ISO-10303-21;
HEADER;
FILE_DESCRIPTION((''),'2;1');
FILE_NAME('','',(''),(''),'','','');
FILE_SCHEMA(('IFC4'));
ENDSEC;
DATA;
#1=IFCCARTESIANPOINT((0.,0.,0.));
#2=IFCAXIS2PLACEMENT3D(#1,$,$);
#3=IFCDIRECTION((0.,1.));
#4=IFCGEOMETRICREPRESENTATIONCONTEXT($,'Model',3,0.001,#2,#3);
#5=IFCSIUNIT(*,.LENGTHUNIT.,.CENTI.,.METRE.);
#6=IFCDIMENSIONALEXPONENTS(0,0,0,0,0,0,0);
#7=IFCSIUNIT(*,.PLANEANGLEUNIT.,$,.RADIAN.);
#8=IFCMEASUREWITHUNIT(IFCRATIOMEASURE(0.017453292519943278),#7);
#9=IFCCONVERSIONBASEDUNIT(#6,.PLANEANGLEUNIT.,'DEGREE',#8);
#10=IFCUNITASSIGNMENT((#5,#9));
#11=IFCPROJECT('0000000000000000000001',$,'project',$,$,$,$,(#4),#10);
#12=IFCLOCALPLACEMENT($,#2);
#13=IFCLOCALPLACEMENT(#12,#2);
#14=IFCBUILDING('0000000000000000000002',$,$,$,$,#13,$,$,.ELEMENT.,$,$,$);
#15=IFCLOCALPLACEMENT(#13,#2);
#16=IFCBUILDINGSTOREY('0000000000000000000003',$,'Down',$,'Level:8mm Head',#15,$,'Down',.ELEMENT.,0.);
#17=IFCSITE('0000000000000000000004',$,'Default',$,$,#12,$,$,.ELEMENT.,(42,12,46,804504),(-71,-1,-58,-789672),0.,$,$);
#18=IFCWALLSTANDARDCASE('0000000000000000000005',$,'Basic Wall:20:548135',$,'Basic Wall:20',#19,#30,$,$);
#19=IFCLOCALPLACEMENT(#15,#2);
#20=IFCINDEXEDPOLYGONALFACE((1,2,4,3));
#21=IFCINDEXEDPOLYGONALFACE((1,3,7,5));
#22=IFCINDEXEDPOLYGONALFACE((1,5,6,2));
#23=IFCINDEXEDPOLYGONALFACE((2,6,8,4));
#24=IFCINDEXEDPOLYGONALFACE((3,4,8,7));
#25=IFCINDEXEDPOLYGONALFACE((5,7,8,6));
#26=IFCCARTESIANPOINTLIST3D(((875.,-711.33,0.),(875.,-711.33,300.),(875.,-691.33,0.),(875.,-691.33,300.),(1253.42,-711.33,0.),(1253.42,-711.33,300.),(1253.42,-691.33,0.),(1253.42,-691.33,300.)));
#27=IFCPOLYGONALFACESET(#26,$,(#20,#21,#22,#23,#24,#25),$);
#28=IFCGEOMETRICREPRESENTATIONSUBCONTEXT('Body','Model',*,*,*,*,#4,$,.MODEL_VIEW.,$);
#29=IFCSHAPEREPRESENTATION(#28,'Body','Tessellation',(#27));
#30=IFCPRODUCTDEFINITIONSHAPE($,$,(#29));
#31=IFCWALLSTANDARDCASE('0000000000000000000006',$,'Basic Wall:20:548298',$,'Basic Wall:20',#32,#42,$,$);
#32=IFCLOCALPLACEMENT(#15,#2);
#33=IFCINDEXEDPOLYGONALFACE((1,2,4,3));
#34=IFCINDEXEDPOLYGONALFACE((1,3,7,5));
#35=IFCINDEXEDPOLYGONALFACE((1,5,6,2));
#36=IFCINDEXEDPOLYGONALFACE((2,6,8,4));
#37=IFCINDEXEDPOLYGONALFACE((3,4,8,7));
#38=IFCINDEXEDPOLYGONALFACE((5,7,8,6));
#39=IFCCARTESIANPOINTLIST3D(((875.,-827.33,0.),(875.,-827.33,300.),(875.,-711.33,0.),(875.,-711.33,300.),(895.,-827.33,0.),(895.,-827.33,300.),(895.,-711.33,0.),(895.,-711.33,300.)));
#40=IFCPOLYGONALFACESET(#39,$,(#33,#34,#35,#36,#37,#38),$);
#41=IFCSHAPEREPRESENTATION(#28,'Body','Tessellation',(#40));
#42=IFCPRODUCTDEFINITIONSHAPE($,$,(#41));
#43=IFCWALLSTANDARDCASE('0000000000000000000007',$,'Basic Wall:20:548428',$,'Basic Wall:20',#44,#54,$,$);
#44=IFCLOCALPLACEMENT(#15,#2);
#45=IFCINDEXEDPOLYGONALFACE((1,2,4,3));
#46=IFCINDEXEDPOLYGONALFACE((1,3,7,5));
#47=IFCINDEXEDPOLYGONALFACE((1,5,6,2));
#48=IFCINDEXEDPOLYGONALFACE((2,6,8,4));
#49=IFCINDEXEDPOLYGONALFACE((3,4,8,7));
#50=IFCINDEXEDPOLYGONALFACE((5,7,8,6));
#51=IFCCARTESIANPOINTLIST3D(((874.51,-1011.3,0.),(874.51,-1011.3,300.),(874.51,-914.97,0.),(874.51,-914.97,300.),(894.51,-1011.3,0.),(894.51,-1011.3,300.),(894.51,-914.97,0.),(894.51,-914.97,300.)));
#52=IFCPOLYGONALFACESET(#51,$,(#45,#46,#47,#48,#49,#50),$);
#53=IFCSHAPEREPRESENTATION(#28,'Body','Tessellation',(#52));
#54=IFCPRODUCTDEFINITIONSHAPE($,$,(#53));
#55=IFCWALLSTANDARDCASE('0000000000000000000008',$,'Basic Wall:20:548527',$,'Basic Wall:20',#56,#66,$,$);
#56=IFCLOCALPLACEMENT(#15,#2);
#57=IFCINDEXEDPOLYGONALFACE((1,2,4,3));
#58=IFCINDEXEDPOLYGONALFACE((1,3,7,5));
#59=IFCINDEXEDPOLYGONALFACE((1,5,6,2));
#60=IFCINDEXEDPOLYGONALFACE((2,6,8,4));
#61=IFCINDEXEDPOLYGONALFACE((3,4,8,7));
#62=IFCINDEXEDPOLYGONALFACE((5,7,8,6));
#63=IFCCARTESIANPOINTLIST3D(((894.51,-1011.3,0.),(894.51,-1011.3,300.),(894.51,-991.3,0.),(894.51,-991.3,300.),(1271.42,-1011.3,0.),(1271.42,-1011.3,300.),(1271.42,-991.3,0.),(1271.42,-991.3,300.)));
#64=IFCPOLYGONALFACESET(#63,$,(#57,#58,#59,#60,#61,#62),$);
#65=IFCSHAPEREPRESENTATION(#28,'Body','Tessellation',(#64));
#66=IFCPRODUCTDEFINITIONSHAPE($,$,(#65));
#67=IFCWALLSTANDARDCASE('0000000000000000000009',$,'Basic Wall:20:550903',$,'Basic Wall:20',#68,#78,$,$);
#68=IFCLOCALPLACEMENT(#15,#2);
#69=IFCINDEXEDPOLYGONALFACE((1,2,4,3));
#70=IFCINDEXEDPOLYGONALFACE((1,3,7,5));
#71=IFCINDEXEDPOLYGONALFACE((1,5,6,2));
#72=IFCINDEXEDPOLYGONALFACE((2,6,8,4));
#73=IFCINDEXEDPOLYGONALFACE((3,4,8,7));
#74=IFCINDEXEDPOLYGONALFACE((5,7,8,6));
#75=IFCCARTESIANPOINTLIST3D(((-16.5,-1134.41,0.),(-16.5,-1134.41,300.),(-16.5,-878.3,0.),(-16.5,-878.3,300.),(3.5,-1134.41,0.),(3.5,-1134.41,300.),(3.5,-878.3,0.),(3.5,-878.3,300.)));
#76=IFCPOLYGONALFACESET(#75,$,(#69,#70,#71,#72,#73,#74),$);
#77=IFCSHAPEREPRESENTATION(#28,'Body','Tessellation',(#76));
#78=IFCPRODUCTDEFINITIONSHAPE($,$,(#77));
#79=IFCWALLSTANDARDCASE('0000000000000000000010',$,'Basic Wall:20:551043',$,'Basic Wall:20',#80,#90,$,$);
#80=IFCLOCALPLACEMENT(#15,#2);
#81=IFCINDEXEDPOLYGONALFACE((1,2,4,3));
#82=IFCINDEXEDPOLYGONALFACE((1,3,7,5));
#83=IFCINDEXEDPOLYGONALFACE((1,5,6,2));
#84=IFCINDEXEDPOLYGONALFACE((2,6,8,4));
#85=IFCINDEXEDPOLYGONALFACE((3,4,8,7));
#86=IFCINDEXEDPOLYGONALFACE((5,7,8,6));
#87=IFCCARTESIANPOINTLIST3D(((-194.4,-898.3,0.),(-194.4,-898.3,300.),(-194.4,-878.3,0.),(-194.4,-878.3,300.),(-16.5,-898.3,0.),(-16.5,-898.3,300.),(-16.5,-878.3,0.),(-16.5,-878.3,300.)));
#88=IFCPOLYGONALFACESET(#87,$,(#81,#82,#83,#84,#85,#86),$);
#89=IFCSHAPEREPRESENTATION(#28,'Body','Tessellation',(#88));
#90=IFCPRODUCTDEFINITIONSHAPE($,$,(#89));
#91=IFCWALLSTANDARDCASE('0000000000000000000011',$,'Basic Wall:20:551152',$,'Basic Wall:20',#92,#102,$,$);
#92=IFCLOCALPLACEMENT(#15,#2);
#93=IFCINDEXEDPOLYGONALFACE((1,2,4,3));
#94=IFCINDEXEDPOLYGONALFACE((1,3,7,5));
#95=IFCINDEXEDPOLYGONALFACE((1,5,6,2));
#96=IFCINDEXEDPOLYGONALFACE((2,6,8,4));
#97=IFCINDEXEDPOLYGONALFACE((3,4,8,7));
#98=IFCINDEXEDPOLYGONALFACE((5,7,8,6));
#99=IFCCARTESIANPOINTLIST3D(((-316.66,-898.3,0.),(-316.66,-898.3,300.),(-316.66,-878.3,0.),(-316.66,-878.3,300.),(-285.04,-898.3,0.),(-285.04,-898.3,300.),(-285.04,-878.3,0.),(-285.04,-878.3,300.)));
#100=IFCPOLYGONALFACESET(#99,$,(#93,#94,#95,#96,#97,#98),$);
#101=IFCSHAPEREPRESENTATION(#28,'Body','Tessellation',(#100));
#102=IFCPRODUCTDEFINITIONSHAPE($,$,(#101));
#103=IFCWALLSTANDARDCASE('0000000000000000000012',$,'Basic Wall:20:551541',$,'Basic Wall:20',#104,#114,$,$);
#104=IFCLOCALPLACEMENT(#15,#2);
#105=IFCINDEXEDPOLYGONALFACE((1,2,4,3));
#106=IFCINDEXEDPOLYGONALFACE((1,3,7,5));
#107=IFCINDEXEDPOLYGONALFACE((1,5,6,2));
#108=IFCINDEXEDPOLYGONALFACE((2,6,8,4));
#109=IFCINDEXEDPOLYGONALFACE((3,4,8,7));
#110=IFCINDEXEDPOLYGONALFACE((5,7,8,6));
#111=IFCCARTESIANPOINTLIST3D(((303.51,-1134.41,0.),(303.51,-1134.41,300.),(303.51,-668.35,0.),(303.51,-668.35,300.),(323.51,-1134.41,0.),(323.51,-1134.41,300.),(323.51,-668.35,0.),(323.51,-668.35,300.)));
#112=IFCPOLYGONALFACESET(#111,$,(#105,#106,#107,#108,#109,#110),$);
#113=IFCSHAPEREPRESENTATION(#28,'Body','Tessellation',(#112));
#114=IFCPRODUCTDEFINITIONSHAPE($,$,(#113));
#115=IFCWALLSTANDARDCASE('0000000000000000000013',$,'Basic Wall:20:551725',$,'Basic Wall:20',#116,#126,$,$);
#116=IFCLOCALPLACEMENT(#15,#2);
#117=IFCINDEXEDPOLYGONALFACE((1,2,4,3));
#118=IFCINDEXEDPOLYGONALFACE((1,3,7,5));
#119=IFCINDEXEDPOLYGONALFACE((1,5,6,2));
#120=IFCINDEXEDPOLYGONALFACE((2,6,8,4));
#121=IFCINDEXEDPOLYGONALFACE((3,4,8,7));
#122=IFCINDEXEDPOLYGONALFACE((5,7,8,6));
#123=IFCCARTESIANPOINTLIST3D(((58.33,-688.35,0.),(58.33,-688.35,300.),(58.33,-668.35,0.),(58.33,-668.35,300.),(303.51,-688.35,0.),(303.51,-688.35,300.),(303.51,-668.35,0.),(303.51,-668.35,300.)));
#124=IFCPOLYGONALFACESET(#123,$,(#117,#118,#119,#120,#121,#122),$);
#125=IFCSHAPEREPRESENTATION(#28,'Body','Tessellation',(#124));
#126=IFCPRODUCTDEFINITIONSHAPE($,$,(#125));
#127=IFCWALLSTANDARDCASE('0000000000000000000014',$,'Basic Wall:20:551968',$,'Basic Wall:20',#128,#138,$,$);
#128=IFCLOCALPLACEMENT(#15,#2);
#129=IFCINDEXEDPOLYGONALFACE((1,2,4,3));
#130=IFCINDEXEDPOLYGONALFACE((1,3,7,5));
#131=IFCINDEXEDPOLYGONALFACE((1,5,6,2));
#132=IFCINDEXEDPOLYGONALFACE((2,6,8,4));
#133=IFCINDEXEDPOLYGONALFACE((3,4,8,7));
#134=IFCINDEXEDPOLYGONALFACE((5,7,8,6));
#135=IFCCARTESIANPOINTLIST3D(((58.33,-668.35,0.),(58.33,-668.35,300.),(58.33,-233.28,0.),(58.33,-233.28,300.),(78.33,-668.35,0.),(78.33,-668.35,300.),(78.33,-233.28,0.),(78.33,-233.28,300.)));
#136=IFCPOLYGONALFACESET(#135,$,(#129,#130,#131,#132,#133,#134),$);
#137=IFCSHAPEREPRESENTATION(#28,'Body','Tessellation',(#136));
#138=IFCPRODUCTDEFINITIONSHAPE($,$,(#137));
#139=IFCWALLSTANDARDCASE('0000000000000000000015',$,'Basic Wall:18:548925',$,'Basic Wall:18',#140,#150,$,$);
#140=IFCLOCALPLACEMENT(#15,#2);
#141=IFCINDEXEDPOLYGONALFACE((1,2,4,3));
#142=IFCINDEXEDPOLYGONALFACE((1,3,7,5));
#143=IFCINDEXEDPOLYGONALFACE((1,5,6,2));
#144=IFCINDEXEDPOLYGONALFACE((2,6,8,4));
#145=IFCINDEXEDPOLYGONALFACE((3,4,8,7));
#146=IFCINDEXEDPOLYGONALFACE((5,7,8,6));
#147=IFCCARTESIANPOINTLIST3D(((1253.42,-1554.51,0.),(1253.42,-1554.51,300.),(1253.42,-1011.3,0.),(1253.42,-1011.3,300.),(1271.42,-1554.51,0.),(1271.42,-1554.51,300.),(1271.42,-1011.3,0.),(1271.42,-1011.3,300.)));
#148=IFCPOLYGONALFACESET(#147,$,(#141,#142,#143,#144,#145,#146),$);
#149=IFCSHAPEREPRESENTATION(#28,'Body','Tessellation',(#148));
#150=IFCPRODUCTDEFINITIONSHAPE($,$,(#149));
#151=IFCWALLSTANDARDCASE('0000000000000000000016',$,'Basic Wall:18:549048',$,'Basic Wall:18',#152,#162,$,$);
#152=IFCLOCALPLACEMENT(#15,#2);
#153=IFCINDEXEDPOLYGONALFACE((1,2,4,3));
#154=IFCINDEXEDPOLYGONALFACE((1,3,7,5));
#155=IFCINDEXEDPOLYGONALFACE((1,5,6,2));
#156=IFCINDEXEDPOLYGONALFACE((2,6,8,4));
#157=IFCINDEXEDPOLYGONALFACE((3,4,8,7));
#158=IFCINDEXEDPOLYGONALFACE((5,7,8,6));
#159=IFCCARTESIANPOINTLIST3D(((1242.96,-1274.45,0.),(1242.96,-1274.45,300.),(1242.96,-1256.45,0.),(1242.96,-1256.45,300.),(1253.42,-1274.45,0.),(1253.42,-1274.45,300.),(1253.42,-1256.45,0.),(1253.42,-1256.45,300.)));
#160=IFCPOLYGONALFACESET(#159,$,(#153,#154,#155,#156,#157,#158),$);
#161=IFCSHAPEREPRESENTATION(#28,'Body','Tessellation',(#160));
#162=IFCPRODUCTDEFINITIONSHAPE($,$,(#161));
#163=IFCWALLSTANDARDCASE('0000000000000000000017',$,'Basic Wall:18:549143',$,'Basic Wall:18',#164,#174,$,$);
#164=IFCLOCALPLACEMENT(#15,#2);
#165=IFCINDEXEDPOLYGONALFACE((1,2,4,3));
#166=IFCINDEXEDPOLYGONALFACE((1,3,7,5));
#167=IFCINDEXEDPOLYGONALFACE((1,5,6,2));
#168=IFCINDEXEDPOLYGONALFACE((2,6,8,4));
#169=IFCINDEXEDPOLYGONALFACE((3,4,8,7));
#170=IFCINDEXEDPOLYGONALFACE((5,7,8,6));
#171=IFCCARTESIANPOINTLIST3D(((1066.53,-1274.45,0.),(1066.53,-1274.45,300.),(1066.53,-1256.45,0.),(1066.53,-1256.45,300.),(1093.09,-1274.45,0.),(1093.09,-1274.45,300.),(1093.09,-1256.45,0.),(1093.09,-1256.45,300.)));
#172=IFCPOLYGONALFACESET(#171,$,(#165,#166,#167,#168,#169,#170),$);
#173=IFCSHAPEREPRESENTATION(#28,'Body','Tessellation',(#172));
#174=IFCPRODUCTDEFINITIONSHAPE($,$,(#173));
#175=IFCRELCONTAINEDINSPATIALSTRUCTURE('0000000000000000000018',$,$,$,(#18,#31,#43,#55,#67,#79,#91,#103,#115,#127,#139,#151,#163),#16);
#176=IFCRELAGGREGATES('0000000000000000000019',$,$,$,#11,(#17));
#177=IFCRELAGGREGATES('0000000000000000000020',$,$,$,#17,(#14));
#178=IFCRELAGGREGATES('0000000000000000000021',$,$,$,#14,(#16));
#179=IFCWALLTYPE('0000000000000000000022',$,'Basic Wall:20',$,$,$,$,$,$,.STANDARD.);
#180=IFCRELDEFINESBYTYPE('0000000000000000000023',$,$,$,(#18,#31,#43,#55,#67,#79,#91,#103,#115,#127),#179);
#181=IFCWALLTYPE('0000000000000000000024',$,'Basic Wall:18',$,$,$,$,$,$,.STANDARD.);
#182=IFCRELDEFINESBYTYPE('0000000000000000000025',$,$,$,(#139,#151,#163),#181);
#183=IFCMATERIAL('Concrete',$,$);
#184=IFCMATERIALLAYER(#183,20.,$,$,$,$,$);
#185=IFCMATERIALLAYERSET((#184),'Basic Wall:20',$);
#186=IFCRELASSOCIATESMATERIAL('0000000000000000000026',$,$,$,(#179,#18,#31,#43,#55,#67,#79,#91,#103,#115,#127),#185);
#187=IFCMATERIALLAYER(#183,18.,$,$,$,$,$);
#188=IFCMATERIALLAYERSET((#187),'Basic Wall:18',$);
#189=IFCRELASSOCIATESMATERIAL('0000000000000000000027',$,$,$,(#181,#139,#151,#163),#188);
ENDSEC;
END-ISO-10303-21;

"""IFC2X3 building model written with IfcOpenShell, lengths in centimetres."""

from ifc_helpers import new_model, entity, si_unit, converted_unit, direction, frame, frame_2d, origin, place, context, subcontext, project, spatial, rectangle, extrude, material, layer, layer_set, layer_usage, type_object, element, save


model = new_model("IFC2X3")

# Units and contexts
model_context = context("Model", 3, precision=0.001, world=origin(), true_north=direction((0.0, 1.0)))
body_context = subcontext(model_context, "Body", "Model", "MODEL_VIEW")
ifc_project = project(units=[si_unit("LENGTHUNIT", "METRE", prefix="CENTI"), converted_unit("PLANEANGLEUNIT", "DEGREE", entity("IfcRatioMeasure", 0.017453292519943278), si_unit("PLANEANGLEUNIT", "RADIAN"), dimensions=[0, 0, 0, 0, 0, 0, 0])], contexts=[model_context])

# Site, building, storey
site_placement = place(None, origin())
site = spatial("IfcSite", under=ifc_project, at=site_placement, Name="Default", CompositionType="ELEMENT", RefLatitude=(42, 12, 46, 804504), RefLongitude=(-71, -1, -58, -789672), RefElevation=0.0)
building_placement = place(site_placement, origin())
building = spatial("IfcBuilding", under=site, at=building_placement, CompositionType="ELEMENT")
storey_placement = place(building_placement, origin())
storey = spatial("IfcBuildingStorey", under=building, at=storey_placement, Name="Down", ObjectType="Level:8mm Head", LongName="Down", CompositionType="ELEMENT", Elevation=0.0)

# Walls
ifc_material = material(Name="Concrete")
ifc_layer_1 = layer(ifc_material, 20.0)
ifc_layer_set_1 = layer_set([ifc_layer_1], Name="Basic Wall:20")
ifc_layer_usage_1 = layer_usage(ifc_layer_set_1, "AXIS2", "POSITIVE", -10.0)
wall_type_1 = type_object("IfcWallType", Name="Basic Wall:20", PredefinedType="STANDARD", material=ifc_layer_set_1)
wall_1_placement = place(storey_placement, frame((1253.42, -701.33, 0.0), z_axis=(0.0, 0.0, 1.0), x_axis=(-1.0, 0.0, 0.0)))
element("IfcWallStandardCase", 1, at=wall_1_placement, inside=storey, type_object=wall_type_1, material=ifc_layer_usage_1, Name="Basic Wall:20:548135", ObjectType="Basic Wall:20", context=body_context, shape_type="SweptSolid", body=[
    extrude(rectangle(XDim=378.42, YDim=20.0, at=frame_2d((189.21, 0.0), x_axis=(-1.0, 0.0))), origin(), (0.0, 0.0, 1.0), 300.0),
])
ifc_layer_usage_2 = layer_usage(ifc_layer_set_1, "AXIS2", "POSITIVE", -10.0)
wall_2_placement = place(storey_placement, frame((885.0, -711.33, 0.0), z_axis=(0.0, 0.0, 1.0), x_axis=(0.0, -1.0, 0.0)))
element("IfcWallStandardCase", 2, at=wall_2_placement, inside=storey, type_object=wall_type_1, material=ifc_layer_usage_2, Name="Basic Wall:20:548298", ObjectType="Basic Wall:20", context=body_context, shape_type="SweptSolid", body=[
    extrude(rectangle(XDim=116.0, YDim=20.0, at=frame_2d((58.0, 0.0), x_axis=(-1.0, 0.0))), origin(), (0.0, 0.0, 1.0), 300.0),
])
ifc_layer_usage_3 = layer_usage(ifc_layer_set_1, "AXIS2", "POSITIVE", -10.0)
wall_3_placement = place(storey_placement, frame((884.51, -914.97, 0.0), z_axis=(0.0, 0.0, 1.0), x_axis=(0.0, -1.0, 0.0)))
element("IfcWallStandardCase", 3, at=wall_3_placement, inside=storey, type_object=wall_type_1, material=ifc_layer_usage_3, Name="Basic Wall:20:548428", ObjectType="Basic Wall:20", context=body_context, shape_type="SweptSolid", body=[
    extrude(rectangle(XDim=96.33, YDim=20.0, at=frame_2d((48.17, 0.0), x_axis=(-1.0, 0.0))), origin(), (0.0, 0.0, 1.0), 300.0),
])
ifc_layer_usage_4 = layer_usage(ifc_layer_set_1, "AXIS2", "POSITIVE", -10.0)
wall_4_placement = place(storey_placement, frame((894.51, -1001.3, 0.0)))
element("IfcWallStandardCase", 4, at=wall_4_placement, inside=storey, type_object=wall_type_1, material=ifc_layer_usage_4, Name="Basic Wall:20:548527", ObjectType="Basic Wall:20", context=body_context, shape_type="SweptSolid", body=[
    extrude(rectangle(XDim=376.91, YDim=20.0, at=frame_2d((188.46, 0.0), x_axis=(-1.0, 0.0))), origin(), (0.0, 0.0, 1.0), 300.0),
])
ifc_layer_usage_5 = layer_usage(ifc_layer_set_1, "AXIS2", "NEGATIVE", 10.0)
wall_5_placement = place(storey_placement, frame((-6.5, -1134.41, 0.0), z_axis=(0.0, 0.0, 1.0), x_axis=(0.0, 1.0, 0.0)))
element("IfcWallStandardCase", 5, at=wall_5_placement, inside=storey, type_object=wall_type_1, material=ifc_layer_usage_5, Name="Basic Wall:20:550903", ObjectType="Basic Wall:20", context=body_context, shape_type="SweptSolid", body=[
    extrude(rectangle(XDim=256.11, YDim=20.0, at=frame_2d((128.05, 0.0), x_axis=(-1.0, 0.0))), origin(), (0.0, 0.0, 1.0), 300.0),
])
ifc_layer_usage_6 = layer_usage(ifc_layer_set_1, "AXIS2", "POSITIVE", -10.0)
wall_6_placement = place(storey_placement, frame((-16.5, -888.3, 0.0), z_axis=(0.0, 0.0, 1.0), x_axis=(-1.0, 0.0, 0.0)))
element("IfcWallStandardCase", 6, at=wall_6_placement, inside=storey, type_object=wall_type_1, material=ifc_layer_usage_6, Name="Basic Wall:20:551043", ObjectType="Basic Wall:20", context=body_context, shape_type="SweptSolid", body=[
    extrude(rectangle(XDim=177.91, YDim=20.0, at=frame_2d((88.95, 0.0), x_axis=(-1.0, 0.0))), origin(), (0.0, 0.0, 1.0), 300.0),
])
ifc_layer_usage_7 = layer_usage(ifc_layer_set_1, "AXIS2", "POSITIVE", -10.0)
wall_7_placement = place(storey_placement, frame((-285.04, -888.3, 0.0), z_axis=(0.0, 0.0, 1.0), x_axis=(-1.0, 0.0, 0.0)))
element("IfcWallStandardCase", 7, at=wall_7_placement, inside=storey, type_object=wall_type_1, material=ifc_layer_usage_7, Name="Basic Wall:20:551152", ObjectType="Basic Wall:20", context=body_context, shape_type="SweptSolid", body=[
    extrude(rectangle(XDim=31.62, YDim=20.0, at=frame_2d((15.81, 0.0), x_axis=(-1.0, 0.0))), origin(), (0.0, 0.0, 1.0), 300.0),
])
ifc_layer_usage_8 = layer_usage(ifc_layer_set_1, "AXIS2", "POSITIVE", -10.0)
wall_8_placement = place(storey_placement, frame((313.51, -1134.41, 0.0), z_axis=(0.0, 0.0, 1.0), x_axis=(0.0, 1.0, 0.0)))
element("IfcWallStandardCase", 8, at=wall_8_placement, inside=storey, type_object=wall_type_1, material=ifc_layer_usage_8, Name="Basic Wall:20:551541", ObjectType="Basic Wall:20", context=body_context, shape_type="SweptSolid", body=[
    extrude(rectangle(XDim=466.05, YDim=20.0, at=frame_2d((233.03, 0.0), x_axis=(-1.0, 0.0))), origin(), (0.0, 0.0, 1.0), 300.0),
])
ifc_layer_usage_9 = layer_usage(ifc_layer_set_1, "AXIS2", "POSITIVE", -10.0)
wall_9_placement = place(storey_placement, frame((303.51, -678.35, 0.0), z_axis=(0.0, 0.0, 1.0), x_axis=(-1.0, 0.0, 0.0)))
element("IfcWallStandardCase", 9, at=wall_9_placement, inside=storey, type_object=wall_type_1, material=ifc_layer_usage_9, Name="Basic Wall:20:551725", ObjectType="Basic Wall:20", context=body_context, shape_type="SweptSolid", body=[
    extrude(rectangle(XDim=245.17, YDim=20.0, at=frame_2d((122.59, 0.0), x_axis=(-1.0, 0.0))), origin(), (0.0, 0.0, 1.0), 300.0),
])
ifc_layer_usage_10 = layer_usage(ifc_layer_set_1, "AXIS2", "NEGATIVE", 10.0)
wall_10_placement = place(storey_placement, frame((68.33, -668.35, 0.0), z_axis=(0.0, 0.0, 1.0), x_axis=(0.0, 1.0, 0.0)))
element("IfcWallStandardCase", 10, at=wall_10_placement, inside=storey, type_object=wall_type_1, material=ifc_layer_usage_10, Name="Basic Wall:20:551968", ObjectType="Basic Wall:20", context=body_context, shape_type="SweptSolid", body=[
    extrude(rectangle(XDim=435.07, YDim=20.0, at=frame_2d((217.53, 0.0), x_axis=(-1.0, 0.0))), origin(), (0.0, 0.0, 1.0), 300.0),
])
ifc_layer_2 = layer(ifc_material, 18.0)
ifc_layer_set_2 = layer_set([ifc_layer_2], Name="Basic Wall:18")
ifc_layer_usage_11 = layer_usage(ifc_layer_set_2, "AXIS2", "NEGATIVE", 9.0)
wall_type_2 = type_object("IfcWallType", Name="Basic Wall:18", PredefinedType="STANDARD", material=ifc_layer_set_2)
wall_11_placement = place(storey_placement, frame((1262.42, -1011.3, 0.0), z_axis=(0.0, 0.0, 1.0), x_axis=(0.0, -1.0, 0.0)))
element("IfcWallStandardCase", 11, at=wall_11_placement, inside=storey, type_object=wall_type_2, material=ifc_layer_usage_11, Name="Basic Wall:18:548925", ObjectType="Basic Wall:18", context=body_context, shape_type="SweptSolid", body=[
    extrude(rectangle(XDim=543.2, YDim=18.0, at=frame_2d((271.6, 0.0), x_axis=(-1.0, 0.0))), origin(), (0.0, 0.0, 1.0), 300.0),
])
ifc_layer_usage_12 = layer_usage(ifc_layer_set_2, "AXIS2", "POSITIVE", -9.0)
wall_12_placement = place(storey_placement, frame((1253.42, -1265.45, 0.0), z_axis=(0.0, 0.0, 1.0), x_axis=(-1.0, 0.0, 0.0)))
element("IfcWallStandardCase", 12, at=wall_12_placement, inside=storey, type_object=wall_type_2, material=ifc_layer_usage_12, Name="Basic Wall:18:549048", ObjectType="Basic Wall:18", context=body_context, shape_type="SweptSolid", body=[
    extrude(rectangle(XDim=10.46, YDim=18.0, at=frame_2d((5.23, 0.0), x_axis=(-1.0, 0.0))), origin(), (0.0, 0.0, 1.0), 300.0),
])
ifc_layer_usage_13 = layer_usage(ifc_layer_set_2, "AXIS2", "POSITIVE", -9.0)
wall_13_placement = place(storey_placement, frame((1093.09, -1265.45, 0.0), z_axis=(0.0, 0.0, 1.0), x_axis=(-1.0, 0.0, 0.0)))
element("IfcWallStandardCase", 13, at=wall_13_placement, inside=storey, type_object=wall_type_2, material=ifc_layer_usage_13, Name="Basic Wall:18:549143", ObjectType="Basic Wall:18", context=body_context, shape_type="SweptSolid", body=[
    extrude(rectangle(XDim=26.56, YDim=18.0, at=frame_2d((13.28, 0.0), x_axis=(-1.0, 0.0))), origin(), (0.0, 0.0, 1.0), 300.0),
])

save(model, "model.ifc")
